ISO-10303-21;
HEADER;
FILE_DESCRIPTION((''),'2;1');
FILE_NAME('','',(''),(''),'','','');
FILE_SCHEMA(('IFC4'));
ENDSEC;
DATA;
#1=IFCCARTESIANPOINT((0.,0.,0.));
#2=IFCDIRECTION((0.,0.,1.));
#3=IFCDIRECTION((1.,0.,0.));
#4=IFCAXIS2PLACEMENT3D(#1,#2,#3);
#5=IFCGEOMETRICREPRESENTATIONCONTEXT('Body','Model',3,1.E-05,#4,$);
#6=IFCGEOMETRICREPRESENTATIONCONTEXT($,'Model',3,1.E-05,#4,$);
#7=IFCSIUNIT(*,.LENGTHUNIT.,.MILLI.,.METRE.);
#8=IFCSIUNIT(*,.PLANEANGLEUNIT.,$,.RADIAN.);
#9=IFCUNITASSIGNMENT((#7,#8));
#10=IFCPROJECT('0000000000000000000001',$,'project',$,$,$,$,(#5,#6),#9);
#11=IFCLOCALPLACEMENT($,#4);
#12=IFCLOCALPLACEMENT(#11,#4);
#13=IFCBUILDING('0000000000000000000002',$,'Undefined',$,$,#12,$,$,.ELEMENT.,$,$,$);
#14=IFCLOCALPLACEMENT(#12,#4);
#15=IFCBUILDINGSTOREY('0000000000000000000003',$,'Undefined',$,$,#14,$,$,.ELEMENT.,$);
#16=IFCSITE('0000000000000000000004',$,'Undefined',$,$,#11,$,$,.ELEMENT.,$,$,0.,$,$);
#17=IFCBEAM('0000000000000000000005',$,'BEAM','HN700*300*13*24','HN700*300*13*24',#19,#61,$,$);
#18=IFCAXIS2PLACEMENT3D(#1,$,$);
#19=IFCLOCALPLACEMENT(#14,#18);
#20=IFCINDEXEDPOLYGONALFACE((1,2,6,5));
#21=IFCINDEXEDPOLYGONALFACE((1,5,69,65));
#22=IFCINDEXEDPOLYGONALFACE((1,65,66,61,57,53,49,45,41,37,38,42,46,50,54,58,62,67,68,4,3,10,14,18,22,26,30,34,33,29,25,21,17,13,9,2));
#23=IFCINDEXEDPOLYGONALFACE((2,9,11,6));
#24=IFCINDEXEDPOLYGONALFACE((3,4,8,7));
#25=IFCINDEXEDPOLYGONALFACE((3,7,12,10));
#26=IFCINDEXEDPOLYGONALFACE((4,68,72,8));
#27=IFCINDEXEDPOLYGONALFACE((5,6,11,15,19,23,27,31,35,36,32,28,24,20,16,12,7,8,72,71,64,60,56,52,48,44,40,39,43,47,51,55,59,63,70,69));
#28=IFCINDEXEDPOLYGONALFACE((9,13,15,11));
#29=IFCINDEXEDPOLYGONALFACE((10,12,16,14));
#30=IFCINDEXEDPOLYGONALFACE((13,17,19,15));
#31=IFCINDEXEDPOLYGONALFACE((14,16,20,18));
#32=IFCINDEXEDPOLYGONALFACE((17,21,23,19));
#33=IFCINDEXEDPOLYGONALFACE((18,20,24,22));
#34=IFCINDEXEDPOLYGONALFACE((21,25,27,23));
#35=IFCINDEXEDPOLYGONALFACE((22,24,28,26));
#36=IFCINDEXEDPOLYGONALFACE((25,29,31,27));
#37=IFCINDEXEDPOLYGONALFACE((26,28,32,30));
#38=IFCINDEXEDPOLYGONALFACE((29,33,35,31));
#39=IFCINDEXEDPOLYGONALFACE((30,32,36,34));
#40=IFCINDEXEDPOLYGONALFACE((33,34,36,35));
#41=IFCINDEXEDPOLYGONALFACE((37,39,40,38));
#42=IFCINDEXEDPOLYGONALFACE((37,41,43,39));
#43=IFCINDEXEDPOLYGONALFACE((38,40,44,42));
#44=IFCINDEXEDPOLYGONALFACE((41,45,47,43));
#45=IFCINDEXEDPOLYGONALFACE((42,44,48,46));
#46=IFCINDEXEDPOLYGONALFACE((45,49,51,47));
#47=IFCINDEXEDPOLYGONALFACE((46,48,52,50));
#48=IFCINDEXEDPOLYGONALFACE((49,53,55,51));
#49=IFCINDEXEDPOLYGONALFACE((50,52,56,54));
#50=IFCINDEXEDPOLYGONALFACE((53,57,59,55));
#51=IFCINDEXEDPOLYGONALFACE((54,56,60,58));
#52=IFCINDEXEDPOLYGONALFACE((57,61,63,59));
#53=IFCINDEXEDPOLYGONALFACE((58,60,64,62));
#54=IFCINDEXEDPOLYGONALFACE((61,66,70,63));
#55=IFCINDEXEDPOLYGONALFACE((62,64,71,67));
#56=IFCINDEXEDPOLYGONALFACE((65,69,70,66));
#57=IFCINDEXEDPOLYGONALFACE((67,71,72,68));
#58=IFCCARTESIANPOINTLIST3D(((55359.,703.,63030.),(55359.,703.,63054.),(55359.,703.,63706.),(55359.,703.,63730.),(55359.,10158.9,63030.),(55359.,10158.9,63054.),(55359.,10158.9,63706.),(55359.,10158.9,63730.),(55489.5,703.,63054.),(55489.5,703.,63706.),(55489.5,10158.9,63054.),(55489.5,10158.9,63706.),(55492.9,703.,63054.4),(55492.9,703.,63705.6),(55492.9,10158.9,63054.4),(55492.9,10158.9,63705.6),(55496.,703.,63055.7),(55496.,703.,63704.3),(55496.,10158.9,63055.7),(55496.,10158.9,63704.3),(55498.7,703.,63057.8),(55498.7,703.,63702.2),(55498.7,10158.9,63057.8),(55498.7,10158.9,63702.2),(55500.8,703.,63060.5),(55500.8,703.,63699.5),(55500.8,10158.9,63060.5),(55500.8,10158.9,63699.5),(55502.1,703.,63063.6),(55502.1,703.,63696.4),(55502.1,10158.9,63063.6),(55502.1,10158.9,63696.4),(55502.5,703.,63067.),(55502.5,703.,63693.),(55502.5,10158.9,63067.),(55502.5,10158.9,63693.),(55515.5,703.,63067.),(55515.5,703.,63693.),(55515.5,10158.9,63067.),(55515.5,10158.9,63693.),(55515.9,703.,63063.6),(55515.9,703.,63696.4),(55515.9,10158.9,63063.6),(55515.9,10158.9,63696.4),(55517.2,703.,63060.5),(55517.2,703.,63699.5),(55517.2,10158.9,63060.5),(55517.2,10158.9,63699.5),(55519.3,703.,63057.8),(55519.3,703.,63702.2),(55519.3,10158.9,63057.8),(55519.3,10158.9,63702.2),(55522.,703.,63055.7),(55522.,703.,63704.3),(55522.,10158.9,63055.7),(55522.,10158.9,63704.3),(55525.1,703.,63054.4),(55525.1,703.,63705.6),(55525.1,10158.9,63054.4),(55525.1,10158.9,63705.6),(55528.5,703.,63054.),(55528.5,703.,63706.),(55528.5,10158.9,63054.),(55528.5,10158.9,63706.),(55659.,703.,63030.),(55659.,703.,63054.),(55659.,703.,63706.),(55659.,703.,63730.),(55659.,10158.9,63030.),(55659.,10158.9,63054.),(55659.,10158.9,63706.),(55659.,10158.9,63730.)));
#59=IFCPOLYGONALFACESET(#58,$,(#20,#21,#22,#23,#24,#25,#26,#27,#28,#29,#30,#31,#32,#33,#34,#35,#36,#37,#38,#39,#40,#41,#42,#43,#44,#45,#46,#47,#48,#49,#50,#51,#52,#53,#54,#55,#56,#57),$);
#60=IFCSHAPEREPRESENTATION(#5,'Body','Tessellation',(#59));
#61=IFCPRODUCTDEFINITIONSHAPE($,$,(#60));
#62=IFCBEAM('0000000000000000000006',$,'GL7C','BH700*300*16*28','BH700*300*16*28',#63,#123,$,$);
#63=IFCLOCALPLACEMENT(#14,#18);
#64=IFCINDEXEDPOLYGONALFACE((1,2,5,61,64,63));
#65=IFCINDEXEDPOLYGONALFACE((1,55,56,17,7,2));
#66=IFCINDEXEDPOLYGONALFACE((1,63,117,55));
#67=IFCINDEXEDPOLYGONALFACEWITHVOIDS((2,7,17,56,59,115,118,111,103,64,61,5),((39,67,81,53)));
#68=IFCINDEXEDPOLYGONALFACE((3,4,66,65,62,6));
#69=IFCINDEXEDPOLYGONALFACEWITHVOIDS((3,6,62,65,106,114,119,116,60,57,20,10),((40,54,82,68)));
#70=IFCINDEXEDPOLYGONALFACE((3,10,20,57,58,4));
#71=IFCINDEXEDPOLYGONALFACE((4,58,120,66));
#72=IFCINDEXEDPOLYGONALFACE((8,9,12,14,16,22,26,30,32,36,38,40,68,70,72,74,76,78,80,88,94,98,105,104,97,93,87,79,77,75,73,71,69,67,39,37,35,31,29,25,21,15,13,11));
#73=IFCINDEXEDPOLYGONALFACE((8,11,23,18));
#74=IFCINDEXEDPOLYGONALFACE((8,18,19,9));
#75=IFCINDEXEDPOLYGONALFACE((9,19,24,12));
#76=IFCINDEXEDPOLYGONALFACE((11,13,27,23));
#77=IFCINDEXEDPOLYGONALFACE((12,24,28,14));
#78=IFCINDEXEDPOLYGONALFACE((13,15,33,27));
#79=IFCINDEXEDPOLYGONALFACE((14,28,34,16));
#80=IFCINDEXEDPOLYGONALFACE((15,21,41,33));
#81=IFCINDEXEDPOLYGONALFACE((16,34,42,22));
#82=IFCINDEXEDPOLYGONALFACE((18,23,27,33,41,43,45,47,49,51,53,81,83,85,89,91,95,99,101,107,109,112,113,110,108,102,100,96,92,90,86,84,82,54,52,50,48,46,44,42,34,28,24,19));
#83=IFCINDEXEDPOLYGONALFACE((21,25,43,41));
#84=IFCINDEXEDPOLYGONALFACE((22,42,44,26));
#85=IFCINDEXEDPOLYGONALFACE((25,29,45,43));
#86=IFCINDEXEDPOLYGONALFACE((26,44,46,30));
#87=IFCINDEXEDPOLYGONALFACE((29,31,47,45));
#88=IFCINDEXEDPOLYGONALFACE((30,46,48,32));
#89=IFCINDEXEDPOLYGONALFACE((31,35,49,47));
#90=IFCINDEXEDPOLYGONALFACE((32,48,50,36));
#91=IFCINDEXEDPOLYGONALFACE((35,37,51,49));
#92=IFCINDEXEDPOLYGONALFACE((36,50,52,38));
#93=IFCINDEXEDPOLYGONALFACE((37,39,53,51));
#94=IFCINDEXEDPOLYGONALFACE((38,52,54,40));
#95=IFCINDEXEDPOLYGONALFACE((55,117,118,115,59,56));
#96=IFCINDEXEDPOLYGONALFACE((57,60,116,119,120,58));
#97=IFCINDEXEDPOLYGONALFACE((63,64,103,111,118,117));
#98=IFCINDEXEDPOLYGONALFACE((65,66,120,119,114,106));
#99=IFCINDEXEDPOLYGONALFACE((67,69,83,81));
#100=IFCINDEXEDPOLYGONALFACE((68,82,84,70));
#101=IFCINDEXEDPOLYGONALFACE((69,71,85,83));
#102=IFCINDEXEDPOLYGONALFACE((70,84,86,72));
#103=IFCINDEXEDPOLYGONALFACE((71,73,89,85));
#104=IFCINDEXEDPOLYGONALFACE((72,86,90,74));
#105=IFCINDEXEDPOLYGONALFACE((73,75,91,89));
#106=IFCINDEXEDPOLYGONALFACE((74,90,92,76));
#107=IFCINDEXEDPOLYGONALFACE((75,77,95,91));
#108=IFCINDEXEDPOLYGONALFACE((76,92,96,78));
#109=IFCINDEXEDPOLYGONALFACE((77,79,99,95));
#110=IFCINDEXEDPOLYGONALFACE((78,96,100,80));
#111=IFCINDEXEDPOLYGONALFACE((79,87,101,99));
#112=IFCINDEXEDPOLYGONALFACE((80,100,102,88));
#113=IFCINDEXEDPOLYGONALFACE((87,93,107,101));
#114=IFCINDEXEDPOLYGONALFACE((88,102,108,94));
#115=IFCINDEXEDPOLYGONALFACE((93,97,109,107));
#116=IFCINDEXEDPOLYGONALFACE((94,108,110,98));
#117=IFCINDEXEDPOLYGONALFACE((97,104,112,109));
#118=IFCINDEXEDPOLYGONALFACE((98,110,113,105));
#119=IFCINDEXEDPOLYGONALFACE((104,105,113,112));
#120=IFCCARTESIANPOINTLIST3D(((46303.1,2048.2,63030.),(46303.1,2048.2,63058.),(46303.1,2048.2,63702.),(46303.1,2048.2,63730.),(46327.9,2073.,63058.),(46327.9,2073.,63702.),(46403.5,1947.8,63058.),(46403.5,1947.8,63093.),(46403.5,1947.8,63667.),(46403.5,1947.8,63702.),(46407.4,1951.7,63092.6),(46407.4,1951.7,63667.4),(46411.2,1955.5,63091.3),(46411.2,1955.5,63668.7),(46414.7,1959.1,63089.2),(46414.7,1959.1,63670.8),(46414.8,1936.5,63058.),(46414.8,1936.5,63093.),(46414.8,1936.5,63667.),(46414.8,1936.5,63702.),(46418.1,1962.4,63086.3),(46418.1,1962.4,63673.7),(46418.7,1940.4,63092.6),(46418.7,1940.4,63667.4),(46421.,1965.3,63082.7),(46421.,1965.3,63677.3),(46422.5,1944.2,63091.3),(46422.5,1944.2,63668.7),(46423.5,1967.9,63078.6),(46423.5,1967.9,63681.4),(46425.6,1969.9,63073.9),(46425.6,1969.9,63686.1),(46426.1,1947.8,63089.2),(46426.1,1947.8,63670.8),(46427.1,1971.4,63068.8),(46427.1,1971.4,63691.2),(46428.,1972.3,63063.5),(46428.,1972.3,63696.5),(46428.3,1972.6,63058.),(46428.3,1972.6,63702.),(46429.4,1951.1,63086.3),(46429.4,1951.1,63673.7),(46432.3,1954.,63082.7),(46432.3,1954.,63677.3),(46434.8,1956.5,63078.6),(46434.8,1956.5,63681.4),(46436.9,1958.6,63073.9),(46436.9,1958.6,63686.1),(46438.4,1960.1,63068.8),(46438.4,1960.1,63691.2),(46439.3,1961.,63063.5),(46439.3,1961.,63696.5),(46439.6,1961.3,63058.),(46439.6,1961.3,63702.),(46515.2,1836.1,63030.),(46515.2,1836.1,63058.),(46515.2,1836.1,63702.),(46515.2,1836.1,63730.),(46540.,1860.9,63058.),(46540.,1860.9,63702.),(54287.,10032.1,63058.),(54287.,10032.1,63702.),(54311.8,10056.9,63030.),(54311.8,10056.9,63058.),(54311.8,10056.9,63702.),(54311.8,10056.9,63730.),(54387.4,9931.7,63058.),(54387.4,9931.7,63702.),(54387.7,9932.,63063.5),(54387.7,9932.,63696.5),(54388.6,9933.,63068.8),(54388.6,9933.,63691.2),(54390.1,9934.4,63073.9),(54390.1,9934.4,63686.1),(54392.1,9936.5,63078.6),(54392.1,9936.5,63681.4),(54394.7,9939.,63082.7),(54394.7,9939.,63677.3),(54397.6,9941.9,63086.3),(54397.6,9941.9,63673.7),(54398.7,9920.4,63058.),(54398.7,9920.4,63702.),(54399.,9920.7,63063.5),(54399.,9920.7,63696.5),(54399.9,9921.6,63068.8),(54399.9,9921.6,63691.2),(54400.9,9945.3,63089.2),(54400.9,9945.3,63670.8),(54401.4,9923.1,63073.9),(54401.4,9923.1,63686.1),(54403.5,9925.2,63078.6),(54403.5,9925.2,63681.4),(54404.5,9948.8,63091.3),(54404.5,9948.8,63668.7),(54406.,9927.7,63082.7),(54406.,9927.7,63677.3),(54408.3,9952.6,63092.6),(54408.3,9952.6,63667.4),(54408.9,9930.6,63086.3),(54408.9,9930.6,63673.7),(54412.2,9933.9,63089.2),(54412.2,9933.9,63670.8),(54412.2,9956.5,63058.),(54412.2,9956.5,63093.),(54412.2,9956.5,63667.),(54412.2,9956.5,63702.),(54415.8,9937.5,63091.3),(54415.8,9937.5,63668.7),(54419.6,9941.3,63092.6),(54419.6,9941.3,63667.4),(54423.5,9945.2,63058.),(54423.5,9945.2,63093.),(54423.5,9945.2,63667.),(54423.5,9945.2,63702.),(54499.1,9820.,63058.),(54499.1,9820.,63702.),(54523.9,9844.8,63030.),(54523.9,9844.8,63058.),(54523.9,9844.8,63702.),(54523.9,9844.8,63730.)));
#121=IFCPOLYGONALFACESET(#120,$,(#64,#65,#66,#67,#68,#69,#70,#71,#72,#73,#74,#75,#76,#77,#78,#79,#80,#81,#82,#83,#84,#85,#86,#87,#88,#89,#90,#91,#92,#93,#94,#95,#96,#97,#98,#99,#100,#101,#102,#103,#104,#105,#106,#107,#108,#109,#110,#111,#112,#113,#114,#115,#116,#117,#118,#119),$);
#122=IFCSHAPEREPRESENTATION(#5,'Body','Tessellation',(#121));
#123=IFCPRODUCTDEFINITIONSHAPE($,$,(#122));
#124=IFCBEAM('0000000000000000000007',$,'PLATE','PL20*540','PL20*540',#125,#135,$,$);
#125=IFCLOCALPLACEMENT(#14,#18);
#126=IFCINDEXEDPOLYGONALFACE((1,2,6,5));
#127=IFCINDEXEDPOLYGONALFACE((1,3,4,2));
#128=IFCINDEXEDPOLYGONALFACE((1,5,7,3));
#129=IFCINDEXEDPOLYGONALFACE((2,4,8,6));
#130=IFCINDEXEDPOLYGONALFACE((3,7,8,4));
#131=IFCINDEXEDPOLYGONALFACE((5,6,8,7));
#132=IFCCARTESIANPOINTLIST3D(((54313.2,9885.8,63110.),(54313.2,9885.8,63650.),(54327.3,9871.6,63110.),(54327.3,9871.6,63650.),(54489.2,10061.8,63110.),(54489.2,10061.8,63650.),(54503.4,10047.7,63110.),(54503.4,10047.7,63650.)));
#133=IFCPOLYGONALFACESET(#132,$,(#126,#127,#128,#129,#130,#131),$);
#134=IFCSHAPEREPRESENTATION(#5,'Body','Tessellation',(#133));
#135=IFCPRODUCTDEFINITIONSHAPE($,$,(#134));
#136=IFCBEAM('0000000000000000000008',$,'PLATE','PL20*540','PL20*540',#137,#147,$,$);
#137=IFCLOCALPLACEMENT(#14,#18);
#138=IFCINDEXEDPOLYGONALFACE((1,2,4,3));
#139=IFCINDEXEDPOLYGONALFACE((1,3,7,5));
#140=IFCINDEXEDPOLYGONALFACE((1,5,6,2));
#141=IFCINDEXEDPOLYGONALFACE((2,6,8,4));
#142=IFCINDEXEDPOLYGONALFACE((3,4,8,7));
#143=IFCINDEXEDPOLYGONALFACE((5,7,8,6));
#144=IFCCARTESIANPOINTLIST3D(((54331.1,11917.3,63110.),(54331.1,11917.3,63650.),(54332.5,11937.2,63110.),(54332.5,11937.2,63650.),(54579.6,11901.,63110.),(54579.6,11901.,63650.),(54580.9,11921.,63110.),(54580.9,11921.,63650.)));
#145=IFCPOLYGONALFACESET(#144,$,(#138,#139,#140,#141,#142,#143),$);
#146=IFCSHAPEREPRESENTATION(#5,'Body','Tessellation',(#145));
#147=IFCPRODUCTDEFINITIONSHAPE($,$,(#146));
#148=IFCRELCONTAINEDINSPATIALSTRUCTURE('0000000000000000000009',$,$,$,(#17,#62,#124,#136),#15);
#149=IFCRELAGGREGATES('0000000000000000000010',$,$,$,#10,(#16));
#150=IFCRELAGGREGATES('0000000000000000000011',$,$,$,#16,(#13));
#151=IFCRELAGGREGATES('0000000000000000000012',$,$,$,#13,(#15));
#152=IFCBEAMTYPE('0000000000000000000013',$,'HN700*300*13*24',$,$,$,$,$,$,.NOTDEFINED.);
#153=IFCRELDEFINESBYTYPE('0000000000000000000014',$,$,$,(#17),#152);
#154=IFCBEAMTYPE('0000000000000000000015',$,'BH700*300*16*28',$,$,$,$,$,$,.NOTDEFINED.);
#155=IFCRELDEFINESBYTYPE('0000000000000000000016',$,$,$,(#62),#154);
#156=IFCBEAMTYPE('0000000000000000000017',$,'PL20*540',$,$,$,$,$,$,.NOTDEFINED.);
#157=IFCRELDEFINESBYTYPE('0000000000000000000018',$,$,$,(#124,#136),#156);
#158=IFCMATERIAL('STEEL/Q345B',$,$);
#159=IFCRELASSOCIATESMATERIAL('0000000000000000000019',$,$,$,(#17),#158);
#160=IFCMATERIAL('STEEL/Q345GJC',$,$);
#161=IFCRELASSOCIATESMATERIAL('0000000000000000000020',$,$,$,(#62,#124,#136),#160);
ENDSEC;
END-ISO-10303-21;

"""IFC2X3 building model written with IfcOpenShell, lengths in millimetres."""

from ifc_helpers import new_model, si_unit, frame, origin_with_axes, origin_2d_with_axis, place, context, project, spatial, polyline, rectangle, i_section, outline, extrude, material, type_object, element, save


model = new_model("IFC2X3")

# Units and contexts
model_context_1 = context("Model", 3, precision=1e-05, world=origin_with_axes(), identifier="Body")
model_context_2 = context("Model", 3, precision=1e-05, world=origin_with_axes())
ifc_project = project(units=[si_unit("LENGTHUNIT", "METRE", prefix="MILLI"), si_unit("PLANEANGLEUNIT", "RADIAN")], contexts=[model_context_1, model_context_2])

# Site, building, storey
site_placement = place(None, origin_with_axes())
site = spatial("IfcSite", under=ifc_project, at=site_placement, Name="Undefined", CompositionType="ELEMENT", RefElevation=0.0)
building_placement = place(site_placement, origin_with_axes())
building = spatial("IfcBuilding", under=site, at=building_placement, Name="Undefined", CompositionType="ELEMENT")
storey_placement = place(building_placement, origin_with_axes())
storey = spatial("IfcBuildingStorey", under=building, at=storey_placement, Name="Undefined", CompositionType="ELEMENT")

# Beam
ifc_material_1 = material(Name="STEEL/Q345B")
beam_type_1 = type_object("IfcBeamType", Name="HN700*300*13*24", PredefinedType="NOTDEFINED")
beam_1_placement = place(storey_placement, frame((55509.0, 10158.9, 63380.0), z_axis=(0.0, 0.0, 1.0), x_axis=(0.0, -1.0, 0.0)))
element("IfcBeam", 1, at=beam_1_placement, inside=storey, type_object=beam_type_1, material=ifc_material_1, Name="BEAM", Description="HN700*300*13*24", ObjectType="HN700*300*13*24", context=model_context_1, shape_type="SweptSolid", body=[
    extrude(i_section(OverallWidth=300.0, OverallDepth=700.0, WebThickness=13.0, FlangeThickness=24.0, FilletRadius=13.0, at=origin_2d_with_axis()), frame((9455.9, 0.0, 0.0), z_axis=(-1.0, 0.0, 0.0), x_axis=(0.0, -1.0, 0.0)), (0.0, 0.0, 1.0), 9455.9),
])

# Beam, openings
ifc_material_2 = material(Name="STEEL/Q345GJC")
beam_type_2 = type_object("IfcBeamType", Name="BH700*300*16*28", PredefinedType="NOTDEFINED")
beam_2_placement = place(storey_placement, frame((55367.7, 10900.7, 63380.0), z_axis=(0.0, 0.0, 1.0), x_axis=(-0.707107, -0.707107, 0.0)))
beam_2 = element("IfcBeam", 2, at=beam_2_placement, inside=storey, type_object=beam_type_2, material=ifc_material_2, Name="GL7C", Description="BH700*300*16*28", ObjectType="BH700*300*16*28", context=model_context_1, shape_type="SweptSolid", body=[
    extrude(i_section(OverallWidth=300.0, OverallDepth=700.0, WebThickness=16.0, FlangeThickness=28.0, at=origin_2d_with_axis()), frame((12669.3, 0.0, 0.0), z_axis=(-1.0, 0.0, 0.0), x_axis=(0.0, -1.0, 0.0)), (0.0, 0.0, 1.0), 11325.9),
])
opening_1_placement = place(storey_placement, frame((55367.7, 10900.7, 63380.0), z_axis=(0.0, 0.0, 1.0), x_axis=(-0.707107, -0.707107, 0.0)))
element("IfcOpeningElement", 3, at=opening_1_placement, cuts=beam_2, ObjectType="Recess", context=model_context_1, shape_type="SweptSolid", body=[
    extrude(outline(polyline([(0.0, 0.0), (37.0, 0.0), (37.0, 35.0), (35.0, 35.0), (29.5, 34.6), (24.2, 33.3), (19.1, 31.2), (14.4, 28.3), (10.3, 24.7), (6.7, 20.6), (3.8, 15.9), (1.7, 10.8), (0.4, 5.5), (0.0, 0.0), (0.0, 0.0)])), frame((1378.4, 150.0, 322.0), z_axis=(0.0, -1.0, 0.0), x_axis=(-1.0, 0.0, 0.0)), (0.0, 0.0, 1.0), 300.0),
])
opening_2_placement = place(storey_placement, frame((55367.7, 10900.7, 63380.0), z_axis=(0.0, 0.0, 1.0), x_axis=(-0.707107, -0.707107, 0.0)))
element("IfcOpeningElement", 4, at=opening_2_placement, cuts=beam_2, ObjectType="Recess", context=model_context_1, shape_type="SweptSolid", body=[
    extrude(outline(polyline([(0.0, 0.0), (37.0, 0.0), (36.6, 5.5), (35.3, 10.8), (33.2, 15.9), (30.3, 20.6), (26.7, 24.7), (22.6, 28.3), (17.9, 31.2), (12.8, 33.3), (7.5, 34.6), (2.0, 35.0), (0.0, 35.0), (0.0, 0.0)])), frame((1341.4, 150.0, -322.0), z_axis=(0.0, -1.0, 0.0), x_axis=(1.0, 0.0, 0.0)), (0.0, 0.0, 1.0), 300.0),
])
opening_3_placement = place(storey_placement, frame((55367.7, 10900.7, 63380.0), z_axis=(0.0, 0.0, 1.0), x_axis=(-0.707107, -0.707107, 0.0)))
element("IfcOpeningElement", 5, at=opening_3_placement, cuts=beam_2, ObjectType="Recess", context=model_context_1, shape_type="SweptSolid", body=[
    extrude(outline(polyline([(0.0, 0.0), (37.0, 0.0), (37.0, 35.0), (35.0, 35.0), (29.5, 34.6), (24.2, 33.3), (19.1, 31.2), (14.4, 28.3), (10.3, 24.7), (6.7, 20.6), (3.8, 15.9), (1.7, 10.8), (0.4, 5.5), (0.0, 0.0), (0.0, 0.0)])), frame((12634.3, -150.0, 322.0), z_axis=(0.0, 1.0, 0.0), x_axis=(1.0, 0.0, 0.0)), (0.0, 0.0, 1.0), 300.0),
])
opening_4_placement = place(storey_placement, frame((55367.7, 10900.7, 63380.0), z_axis=(0.0, 0.0, 1.0), x_axis=(-0.707107, -0.707107, 0.0)))
element("IfcOpeningElement", 6, at=opening_4_placement, cuts=beam_2, ObjectType="Recess", context=model_context_1, shape_type="SweptSolid", body=[
    extrude(outline(polyline([(0.0, 0.0), (37.0, 0.0), (36.6, 5.5), (35.3, 10.8), (33.2, 15.9), (30.3, 20.6), (26.7, 24.7), (22.6, 28.3), (17.9, 31.2), (12.8, 33.3), (7.5, 34.6), (2.0, 35.0), (0.0, 35.0), (0.0, 0.0)])), frame((12671.3, -150.0, -322.0), z_axis=(0.0, 1.0, 0.0), x_axis=(-1.0, 0.0, 0.0)), (0.0, 0.0, 1.0), 300.0),
])
opening_5_placement = place(storey_placement, frame((55367.7, 10900.7, 63380.0), z_axis=(0.0, 0.0, 1.0), x_axis=(-0.707107, -0.707107, 0.0)))
element("IfcOpeningElement", 7, at=opening_5_placement, cuts=beam_2, ObjectType="Recess", context=model_context_1, shape_type="SweptSolid", body=[
    extrude(outline(polyline([(0.0, 0.0), (37.0, 0.0), (37.0, 35.0), (35.0, 35.0), (29.5, 34.6), (24.2, 33.3), (19.1, 31.2), (14.4, 28.3), (10.3, 24.7), (6.7, 20.6), (3.8, 15.9), (1.7, 10.8), (0.4, 5.5), (0.0, 0.0), (0.0, 0.0)])), frame((12634.3, -150.0, 322.0), z_axis=(0.0, 1.0, 0.0), x_axis=(1.0, 0.0, 0.0)), (0.0, 0.0, 1.0), 300.0),
])
opening_6_placement = place(storey_placement, frame((55367.7, 10900.7, 63380.0), z_axis=(0.0, 0.0, 1.0), x_axis=(-0.707107, -0.707107, 0.0)))
element("IfcOpeningElement", 8, at=opening_6_placement, cuts=beam_2, ObjectType="Recess", context=model_context_1, shape_type="SweptSolid", body=[
    extrude(outline(polyline([(0.0, 0.0), (37.0, 0.0), (36.6, 5.5), (35.3, 10.8), (33.2, 15.9), (30.3, 20.6), (26.7, 24.7), (22.6, 28.3), (17.9, 31.2), (12.8, 33.3), (7.5, 34.6), (2.0, 35.0), (0.0, 35.0), (0.0, 0.0)])), frame((12671.3, -150.0, -322.0), z_axis=(0.0, 1.0, 0.0), x_axis=(-1.0, 0.0, 0.0)), (0.0, 0.0, 1.0), 300.0),
])

# Beams
beam_type_3 = type_object("IfcBeamType", Name="PL20*540", PredefinedType="NOTDEFINED")
beam_3_placement = place(storey_placement, frame((54496.3, 10054.8, 63380.0), z_axis=(0.0, 0.0, 1.0), x_axis=(-0.707107, -0.707107, 0.0)))
element("IfcBeam", 9, at=beam_3_placement, inside=storey, type_object=beam_type_3, material=ifc_material_2, Name="PLATE", Description="PL20*540", ObjectType="PL20*540", context=model_context_1, shape_type="SweptSolid", body=[
    extrude(rectangle(XDim=20.0, YDim=540.0, at=origin_2d_with_axis()), frame((249.0, 0.0, 0.0), z_axis=(-1.0, 0.0, 0.0), x_axis=(0.0, -1.0, 0.0)), (0.0, 0.0, 1.0), 249.0),
])
beam_4_placement = place(storey_placement, frame((54580.3, 11911.0, 63380.0), z_axis=(0.0, 0.0, 1.0), x_axis=(-0.997873, 0.065184, 0.0)))
element("IfcBeam", 10, at=beam_4_placement, inside=storey, type_object=beam_type_3, material=ifc_material_2, Name="PLATE", Description="PL20*540", ObjectType="PL20*540", context=model_context_1, shape_type="SweptSolid", body=[
    extrude(rectangle(XDim=20.0, YDim=540.0, at=origin_2d_with_axis()), frame((249.0, 0.0, 0.0), z_axis=(-1.0, 0.0, 0.0), x_axis=(0.0, -1.0, 0.0)), (0.0, 0.0, 1.0), 249.0),
])

save(model, "model.ifc")
